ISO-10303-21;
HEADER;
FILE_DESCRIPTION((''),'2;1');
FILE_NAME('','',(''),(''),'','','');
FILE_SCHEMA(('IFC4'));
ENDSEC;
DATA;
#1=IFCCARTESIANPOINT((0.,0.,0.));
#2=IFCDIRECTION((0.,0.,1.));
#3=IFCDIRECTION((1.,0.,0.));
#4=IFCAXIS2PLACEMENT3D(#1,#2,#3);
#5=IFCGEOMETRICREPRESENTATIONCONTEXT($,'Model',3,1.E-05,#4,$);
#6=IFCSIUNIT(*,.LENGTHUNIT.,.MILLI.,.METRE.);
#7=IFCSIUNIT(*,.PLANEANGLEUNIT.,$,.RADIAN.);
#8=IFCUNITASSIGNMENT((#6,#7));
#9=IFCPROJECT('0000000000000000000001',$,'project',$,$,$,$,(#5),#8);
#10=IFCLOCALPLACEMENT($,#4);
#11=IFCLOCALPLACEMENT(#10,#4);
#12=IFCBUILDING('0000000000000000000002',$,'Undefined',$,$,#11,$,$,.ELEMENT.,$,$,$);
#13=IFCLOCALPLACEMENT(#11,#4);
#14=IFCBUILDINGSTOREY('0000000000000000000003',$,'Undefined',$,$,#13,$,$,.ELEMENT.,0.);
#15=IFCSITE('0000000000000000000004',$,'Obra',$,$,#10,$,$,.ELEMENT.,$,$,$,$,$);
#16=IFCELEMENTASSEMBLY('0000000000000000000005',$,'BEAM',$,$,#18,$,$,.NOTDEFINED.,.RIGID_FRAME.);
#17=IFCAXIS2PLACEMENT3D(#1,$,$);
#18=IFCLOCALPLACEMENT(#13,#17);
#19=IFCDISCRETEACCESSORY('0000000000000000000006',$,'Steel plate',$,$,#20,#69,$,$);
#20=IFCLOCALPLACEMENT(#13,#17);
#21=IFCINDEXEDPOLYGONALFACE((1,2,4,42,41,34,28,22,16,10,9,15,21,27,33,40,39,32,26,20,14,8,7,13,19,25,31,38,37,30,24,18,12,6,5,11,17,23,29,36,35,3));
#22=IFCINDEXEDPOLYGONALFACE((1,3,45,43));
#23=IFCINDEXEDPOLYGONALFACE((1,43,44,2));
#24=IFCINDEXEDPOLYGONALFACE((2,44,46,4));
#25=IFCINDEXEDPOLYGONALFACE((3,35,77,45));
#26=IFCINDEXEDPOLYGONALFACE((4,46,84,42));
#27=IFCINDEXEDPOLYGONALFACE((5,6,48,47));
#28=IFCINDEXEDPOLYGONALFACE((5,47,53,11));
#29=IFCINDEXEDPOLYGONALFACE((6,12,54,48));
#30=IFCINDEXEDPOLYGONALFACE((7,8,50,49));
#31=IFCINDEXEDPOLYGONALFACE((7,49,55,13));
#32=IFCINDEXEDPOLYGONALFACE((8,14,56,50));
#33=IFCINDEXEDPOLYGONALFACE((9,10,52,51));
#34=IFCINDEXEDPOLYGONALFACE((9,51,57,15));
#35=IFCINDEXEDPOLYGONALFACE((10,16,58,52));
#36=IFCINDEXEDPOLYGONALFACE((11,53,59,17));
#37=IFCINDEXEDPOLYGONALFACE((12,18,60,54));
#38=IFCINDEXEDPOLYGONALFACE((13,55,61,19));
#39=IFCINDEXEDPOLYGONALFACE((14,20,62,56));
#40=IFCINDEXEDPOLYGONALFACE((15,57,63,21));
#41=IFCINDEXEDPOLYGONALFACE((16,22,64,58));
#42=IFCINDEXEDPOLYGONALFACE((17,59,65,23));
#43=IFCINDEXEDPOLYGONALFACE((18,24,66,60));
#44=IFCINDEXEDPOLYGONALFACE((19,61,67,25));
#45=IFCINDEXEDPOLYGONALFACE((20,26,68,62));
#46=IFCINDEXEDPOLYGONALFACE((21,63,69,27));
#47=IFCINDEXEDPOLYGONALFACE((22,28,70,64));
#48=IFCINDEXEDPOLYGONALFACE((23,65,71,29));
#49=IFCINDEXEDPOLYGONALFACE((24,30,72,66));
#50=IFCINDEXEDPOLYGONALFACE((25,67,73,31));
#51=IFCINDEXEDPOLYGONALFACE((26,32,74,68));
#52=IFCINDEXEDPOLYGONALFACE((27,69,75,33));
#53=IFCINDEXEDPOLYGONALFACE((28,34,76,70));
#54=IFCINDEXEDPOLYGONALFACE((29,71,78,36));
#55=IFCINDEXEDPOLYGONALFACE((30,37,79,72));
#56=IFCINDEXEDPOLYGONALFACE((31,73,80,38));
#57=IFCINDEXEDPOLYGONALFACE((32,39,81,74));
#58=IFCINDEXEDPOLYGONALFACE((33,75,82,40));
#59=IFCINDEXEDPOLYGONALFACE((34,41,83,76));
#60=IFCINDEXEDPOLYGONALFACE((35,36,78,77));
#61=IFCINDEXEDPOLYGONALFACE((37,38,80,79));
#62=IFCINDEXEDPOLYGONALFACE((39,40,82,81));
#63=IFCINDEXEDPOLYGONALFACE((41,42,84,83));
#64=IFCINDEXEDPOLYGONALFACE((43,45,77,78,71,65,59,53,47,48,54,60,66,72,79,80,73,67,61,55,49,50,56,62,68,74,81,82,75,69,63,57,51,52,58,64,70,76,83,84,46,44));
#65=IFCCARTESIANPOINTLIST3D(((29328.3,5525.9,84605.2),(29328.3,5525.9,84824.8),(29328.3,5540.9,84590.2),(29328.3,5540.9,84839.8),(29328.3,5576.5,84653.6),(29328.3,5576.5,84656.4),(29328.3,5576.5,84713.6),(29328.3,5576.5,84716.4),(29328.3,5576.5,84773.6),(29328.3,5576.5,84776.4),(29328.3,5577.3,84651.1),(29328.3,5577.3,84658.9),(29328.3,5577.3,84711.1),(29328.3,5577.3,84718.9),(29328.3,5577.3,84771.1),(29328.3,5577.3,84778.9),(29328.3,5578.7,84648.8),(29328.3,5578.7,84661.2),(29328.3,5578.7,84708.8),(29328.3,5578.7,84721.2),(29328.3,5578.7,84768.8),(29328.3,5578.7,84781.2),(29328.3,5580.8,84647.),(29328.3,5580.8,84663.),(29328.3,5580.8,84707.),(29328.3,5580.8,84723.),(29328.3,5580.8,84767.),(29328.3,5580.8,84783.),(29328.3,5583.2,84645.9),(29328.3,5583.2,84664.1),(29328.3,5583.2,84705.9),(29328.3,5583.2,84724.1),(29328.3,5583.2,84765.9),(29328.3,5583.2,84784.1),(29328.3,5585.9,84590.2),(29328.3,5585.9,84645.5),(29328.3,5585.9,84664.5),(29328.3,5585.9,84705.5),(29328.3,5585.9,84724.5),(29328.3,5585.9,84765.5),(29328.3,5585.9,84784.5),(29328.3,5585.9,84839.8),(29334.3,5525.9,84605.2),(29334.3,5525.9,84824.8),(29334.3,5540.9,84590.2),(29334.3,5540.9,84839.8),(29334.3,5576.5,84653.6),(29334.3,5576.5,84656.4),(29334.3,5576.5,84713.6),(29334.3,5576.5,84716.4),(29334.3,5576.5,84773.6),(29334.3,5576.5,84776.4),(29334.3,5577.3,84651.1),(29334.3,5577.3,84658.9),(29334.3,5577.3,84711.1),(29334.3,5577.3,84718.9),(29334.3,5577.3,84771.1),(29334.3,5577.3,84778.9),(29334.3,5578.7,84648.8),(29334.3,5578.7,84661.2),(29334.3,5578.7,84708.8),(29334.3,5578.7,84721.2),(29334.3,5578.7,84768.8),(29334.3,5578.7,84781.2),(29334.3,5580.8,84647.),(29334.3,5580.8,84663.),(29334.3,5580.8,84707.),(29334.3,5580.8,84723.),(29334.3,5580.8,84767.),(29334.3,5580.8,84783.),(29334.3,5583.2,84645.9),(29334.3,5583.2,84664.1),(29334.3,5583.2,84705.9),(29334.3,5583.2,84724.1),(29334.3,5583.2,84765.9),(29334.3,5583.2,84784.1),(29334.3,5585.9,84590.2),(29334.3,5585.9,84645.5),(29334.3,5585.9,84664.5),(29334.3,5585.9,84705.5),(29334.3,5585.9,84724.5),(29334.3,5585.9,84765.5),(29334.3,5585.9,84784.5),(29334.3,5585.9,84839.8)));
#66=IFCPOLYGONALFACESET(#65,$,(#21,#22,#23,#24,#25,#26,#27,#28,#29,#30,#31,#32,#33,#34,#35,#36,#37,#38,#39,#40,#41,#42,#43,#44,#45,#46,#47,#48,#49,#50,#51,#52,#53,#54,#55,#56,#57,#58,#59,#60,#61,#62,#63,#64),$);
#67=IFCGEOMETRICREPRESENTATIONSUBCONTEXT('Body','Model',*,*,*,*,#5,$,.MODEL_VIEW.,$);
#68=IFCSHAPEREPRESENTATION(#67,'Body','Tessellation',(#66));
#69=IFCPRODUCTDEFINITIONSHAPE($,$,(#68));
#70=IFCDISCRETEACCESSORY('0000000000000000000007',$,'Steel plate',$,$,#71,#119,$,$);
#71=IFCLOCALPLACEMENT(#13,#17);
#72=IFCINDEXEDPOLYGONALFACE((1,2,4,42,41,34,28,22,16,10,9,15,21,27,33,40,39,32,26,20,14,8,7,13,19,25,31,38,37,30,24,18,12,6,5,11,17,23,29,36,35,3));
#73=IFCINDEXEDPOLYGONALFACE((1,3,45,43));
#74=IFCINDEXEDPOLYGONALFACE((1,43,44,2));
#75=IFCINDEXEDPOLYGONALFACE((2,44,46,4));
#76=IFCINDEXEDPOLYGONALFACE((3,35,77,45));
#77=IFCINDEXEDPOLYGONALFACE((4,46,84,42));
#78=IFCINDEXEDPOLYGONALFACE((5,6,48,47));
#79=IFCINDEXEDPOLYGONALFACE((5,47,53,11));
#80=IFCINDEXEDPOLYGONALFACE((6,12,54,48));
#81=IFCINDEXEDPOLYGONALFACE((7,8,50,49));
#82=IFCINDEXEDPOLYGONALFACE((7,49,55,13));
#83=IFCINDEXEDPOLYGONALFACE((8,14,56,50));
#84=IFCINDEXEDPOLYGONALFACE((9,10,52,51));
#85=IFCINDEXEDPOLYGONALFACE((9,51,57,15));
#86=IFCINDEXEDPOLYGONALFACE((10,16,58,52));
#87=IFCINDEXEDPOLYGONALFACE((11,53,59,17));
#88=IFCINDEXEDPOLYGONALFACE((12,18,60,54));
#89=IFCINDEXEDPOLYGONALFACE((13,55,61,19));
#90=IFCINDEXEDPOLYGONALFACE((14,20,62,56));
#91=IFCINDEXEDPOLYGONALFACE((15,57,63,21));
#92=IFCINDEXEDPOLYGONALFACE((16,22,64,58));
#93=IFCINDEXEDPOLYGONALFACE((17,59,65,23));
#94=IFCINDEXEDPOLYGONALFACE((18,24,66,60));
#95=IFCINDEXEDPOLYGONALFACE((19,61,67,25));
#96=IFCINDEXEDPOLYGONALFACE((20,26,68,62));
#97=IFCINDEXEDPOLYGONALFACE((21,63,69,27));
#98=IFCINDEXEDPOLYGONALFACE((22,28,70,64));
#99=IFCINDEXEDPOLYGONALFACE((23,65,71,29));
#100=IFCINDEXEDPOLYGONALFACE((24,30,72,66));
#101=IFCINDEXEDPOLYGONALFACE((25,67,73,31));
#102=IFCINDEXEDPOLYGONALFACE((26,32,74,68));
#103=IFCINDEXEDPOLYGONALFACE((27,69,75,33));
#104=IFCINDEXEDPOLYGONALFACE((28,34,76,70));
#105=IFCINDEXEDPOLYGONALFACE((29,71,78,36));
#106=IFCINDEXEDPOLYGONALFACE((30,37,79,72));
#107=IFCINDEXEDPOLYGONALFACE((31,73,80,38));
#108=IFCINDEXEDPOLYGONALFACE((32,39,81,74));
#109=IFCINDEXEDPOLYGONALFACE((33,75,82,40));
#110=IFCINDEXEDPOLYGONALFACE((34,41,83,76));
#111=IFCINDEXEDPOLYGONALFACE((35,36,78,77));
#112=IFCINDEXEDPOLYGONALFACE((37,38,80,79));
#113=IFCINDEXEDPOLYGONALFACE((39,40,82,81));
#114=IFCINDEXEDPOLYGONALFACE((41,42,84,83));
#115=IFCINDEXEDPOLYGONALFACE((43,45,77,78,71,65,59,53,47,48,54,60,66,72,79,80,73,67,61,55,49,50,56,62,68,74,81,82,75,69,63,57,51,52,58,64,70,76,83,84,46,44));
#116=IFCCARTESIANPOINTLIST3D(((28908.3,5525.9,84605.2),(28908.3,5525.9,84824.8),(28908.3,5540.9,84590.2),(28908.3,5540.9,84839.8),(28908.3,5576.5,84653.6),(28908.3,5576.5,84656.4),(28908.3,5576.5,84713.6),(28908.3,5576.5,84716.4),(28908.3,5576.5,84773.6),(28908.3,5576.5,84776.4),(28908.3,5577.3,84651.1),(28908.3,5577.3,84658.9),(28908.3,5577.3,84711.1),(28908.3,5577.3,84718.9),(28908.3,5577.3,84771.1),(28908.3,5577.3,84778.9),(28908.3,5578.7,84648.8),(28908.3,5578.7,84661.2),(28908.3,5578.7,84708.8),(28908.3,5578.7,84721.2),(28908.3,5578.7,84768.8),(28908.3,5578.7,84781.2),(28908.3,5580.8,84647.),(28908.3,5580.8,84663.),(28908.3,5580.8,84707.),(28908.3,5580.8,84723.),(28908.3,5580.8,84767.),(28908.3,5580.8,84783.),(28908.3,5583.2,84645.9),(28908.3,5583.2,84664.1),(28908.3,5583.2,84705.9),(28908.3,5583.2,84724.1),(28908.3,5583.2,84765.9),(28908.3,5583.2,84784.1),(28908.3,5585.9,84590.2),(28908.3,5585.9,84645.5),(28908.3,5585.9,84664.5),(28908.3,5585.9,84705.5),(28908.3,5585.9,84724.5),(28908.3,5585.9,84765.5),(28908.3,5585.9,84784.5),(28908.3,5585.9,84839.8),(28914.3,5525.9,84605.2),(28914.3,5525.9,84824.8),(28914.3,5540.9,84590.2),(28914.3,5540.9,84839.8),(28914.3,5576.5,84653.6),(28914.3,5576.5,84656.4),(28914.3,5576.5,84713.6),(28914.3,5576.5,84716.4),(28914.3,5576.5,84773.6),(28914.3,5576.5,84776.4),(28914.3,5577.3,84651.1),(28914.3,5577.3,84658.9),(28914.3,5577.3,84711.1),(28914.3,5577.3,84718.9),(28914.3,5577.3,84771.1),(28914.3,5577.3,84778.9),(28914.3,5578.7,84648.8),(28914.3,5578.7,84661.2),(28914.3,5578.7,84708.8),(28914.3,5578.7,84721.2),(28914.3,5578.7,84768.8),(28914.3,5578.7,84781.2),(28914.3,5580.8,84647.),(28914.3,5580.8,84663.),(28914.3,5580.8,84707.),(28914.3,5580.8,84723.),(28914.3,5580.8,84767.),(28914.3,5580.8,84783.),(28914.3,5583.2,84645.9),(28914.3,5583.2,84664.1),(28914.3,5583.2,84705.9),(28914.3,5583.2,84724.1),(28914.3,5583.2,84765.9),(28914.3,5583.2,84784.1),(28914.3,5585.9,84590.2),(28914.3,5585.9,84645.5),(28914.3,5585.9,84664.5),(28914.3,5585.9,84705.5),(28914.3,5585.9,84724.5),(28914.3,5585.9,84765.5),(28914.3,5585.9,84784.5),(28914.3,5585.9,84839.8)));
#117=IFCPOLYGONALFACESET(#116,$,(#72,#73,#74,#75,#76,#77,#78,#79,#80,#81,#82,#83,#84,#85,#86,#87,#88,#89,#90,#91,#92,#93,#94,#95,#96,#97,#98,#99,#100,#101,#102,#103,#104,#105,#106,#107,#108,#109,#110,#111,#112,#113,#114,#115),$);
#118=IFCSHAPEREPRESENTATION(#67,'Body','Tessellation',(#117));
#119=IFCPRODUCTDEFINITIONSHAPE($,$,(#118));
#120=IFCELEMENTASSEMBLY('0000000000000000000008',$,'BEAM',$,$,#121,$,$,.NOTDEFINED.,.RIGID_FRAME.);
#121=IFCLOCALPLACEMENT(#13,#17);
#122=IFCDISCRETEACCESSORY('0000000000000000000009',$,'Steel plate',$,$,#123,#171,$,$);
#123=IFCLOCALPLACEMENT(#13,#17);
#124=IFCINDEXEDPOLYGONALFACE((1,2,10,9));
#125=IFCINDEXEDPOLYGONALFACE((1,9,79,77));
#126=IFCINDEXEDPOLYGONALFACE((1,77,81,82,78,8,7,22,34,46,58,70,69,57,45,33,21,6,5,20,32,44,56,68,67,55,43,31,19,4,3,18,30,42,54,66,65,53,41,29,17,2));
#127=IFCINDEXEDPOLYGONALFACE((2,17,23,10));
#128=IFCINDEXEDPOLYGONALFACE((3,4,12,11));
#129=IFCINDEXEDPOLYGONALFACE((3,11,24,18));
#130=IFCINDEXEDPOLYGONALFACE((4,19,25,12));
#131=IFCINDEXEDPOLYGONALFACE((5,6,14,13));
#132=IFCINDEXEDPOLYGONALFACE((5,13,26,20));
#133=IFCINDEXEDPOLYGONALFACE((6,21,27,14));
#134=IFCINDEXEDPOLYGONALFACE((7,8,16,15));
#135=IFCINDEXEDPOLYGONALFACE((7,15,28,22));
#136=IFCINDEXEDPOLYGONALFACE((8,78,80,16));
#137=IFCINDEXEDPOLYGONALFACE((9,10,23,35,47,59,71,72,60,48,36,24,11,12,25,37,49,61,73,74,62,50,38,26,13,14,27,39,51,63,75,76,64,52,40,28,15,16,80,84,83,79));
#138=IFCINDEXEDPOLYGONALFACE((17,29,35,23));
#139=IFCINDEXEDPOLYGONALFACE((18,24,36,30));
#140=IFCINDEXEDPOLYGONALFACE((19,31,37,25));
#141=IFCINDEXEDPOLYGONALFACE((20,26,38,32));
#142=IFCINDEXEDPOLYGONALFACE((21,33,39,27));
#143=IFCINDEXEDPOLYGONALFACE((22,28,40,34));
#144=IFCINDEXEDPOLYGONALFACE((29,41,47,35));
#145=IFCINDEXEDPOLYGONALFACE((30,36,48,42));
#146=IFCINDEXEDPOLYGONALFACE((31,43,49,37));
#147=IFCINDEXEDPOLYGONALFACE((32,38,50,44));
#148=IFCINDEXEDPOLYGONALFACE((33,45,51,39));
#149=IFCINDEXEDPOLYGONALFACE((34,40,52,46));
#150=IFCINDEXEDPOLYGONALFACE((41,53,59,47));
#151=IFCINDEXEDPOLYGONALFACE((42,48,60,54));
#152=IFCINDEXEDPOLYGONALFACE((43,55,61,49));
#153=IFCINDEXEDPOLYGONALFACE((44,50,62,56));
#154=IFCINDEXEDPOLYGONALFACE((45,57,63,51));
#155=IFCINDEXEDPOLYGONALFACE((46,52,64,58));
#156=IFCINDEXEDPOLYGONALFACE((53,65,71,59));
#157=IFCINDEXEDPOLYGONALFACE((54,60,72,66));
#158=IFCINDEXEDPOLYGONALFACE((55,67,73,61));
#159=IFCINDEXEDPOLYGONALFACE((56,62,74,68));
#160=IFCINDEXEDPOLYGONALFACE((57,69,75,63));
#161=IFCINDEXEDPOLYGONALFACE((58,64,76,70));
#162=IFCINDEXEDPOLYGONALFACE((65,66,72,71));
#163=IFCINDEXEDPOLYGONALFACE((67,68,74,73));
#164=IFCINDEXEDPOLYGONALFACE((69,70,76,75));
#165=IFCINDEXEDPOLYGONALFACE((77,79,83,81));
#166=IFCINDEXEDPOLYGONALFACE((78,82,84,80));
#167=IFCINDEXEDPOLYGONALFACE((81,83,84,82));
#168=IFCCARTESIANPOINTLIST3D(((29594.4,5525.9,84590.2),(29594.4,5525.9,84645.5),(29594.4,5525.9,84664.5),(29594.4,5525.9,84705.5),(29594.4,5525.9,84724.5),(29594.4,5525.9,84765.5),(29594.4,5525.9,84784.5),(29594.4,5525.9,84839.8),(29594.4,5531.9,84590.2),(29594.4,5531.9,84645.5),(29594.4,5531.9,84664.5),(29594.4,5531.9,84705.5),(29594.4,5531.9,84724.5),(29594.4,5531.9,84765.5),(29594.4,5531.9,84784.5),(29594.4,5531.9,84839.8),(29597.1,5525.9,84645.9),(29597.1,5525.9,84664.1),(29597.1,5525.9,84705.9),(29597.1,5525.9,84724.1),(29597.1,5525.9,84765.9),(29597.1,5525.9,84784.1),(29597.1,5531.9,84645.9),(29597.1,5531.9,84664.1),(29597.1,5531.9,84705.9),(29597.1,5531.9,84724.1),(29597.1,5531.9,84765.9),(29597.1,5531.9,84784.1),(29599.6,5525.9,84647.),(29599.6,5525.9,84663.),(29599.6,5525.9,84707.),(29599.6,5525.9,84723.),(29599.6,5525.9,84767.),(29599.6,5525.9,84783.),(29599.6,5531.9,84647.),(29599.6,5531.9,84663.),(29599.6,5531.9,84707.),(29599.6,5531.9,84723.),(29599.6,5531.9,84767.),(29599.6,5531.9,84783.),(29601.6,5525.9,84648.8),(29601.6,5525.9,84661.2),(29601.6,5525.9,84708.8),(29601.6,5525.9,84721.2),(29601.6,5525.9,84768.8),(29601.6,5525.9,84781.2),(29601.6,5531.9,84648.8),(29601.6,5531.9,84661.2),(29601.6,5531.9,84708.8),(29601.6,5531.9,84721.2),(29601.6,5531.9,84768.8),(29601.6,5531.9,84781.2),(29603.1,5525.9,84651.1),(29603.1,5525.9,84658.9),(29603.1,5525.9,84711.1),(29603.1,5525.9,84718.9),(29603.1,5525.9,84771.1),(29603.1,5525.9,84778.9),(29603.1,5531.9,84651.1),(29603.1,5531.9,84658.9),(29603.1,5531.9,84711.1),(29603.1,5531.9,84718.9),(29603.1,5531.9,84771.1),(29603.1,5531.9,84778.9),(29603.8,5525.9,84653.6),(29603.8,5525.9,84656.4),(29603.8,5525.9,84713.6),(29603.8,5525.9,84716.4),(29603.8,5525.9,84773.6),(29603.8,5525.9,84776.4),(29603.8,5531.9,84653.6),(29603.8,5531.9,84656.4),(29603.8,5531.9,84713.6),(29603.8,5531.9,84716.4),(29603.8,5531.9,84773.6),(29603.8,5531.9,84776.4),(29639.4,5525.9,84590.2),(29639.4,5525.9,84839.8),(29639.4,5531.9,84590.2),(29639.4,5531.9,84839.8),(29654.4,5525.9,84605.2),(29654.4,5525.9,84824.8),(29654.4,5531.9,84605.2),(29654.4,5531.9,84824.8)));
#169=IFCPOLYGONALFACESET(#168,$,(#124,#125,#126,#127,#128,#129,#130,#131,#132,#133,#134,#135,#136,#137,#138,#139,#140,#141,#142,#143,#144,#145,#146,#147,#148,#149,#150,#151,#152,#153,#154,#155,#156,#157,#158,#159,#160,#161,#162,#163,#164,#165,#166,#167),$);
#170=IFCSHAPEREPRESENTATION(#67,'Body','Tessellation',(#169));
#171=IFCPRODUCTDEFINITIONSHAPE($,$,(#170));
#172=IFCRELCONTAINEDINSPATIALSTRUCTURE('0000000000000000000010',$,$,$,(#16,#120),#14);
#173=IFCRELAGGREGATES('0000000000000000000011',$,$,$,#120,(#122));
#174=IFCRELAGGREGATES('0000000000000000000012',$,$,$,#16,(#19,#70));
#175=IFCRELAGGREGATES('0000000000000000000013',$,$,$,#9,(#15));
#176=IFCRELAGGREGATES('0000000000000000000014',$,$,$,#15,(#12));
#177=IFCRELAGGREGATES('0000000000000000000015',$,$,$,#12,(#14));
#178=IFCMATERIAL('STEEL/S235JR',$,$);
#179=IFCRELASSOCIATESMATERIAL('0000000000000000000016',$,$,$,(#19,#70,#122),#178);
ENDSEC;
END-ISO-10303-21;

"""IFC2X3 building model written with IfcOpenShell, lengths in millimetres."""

from ifc_helpers import new_model, si_unit, frame, origin_with_axes, origin_2d_with_axis, place, context, subcontext, project, spatial, polyline, circle, outline, extrude, source, transform, mapped, material, element, aggregate, save


model = new_model("IFC2X3")

# Units and contexts
model_context = context("Model", 3, precision=1e-05, world=origin_with_axes())
body_context = subcontext(model_context, "Body", "Model", "MODEL_VIEW")
ifc_project = project(units=[si_unit("LENGTHUNIT", "METRE", prefix="MILLI"), si_unit("PLANEANGLEUNIT", "RADIAN")], contexts=[model_context])

# Site, building, storey
site_placement = place(None, origin_with_axes())
site = spatial("IfcSite", under=ifc_project, at=site_placement, Name="Obra", CompositionType="ELEMENT")
building_placement = place(site_placement, origin_with_axes())
building = spatial("IfcBuilding", under=site, at=building_placement, Name="Undefined", CompositionType="ELEMENT")
storey_placement = place(building_placement, origin_with_axes())
storey = spatial("IfcBuildingStorey", under=building, at=storey_placement, Name="Undefined", CompositionType="ELEMENT", Elevation=0.0)

# Shared definitions
ifc_material_1 = material(Name="STEEL/S235JR")

# Element assembly, discrete accessories, openings
assembly_1_placement = place(storey_placement, origin_with_axes())
assembly_1 = element("IfcElementAssembly", 1, at=assembly_1_placement, inside=storey, Name="BEAM", AssemblyPlace="NOTDEFINED", PredefinedType="RIGID_FRAME")
discrete_accessory_1_placement = place(assembly_1_placement, frame((29331.3, 5585.9, 84590.2), z_axis=(-1.0, -0.000002, 0.0), x_axis=(0.000002, -1.0, 0.0)))
discrete_accessory_1 = element("IfcDiscreteAccessory", 2, at=discrete_accessory_1_placement, material=ifc_material_1, Name="Steel plate", context=body_context, shape_type="SweptSolid", body=[
    extrude(outline(polyline([(0.0, 0.0), (45.0, 0.0), (60.0, 15.0), (60.0, 234.6), (45.0, 249.6), (0.0, 249.6), (0.0, 0.0)])), frame((0.0, 0.0, -3.0), z_axis=(0.0, 0.0, 1.0), x_axis=(1.0, 0.0, 0.0)), (0.0, 0.0, 1.0), 6.0),
])
shared_shape_1 = source(origin_with_axes(), body_context, "Body", "SweptSolid", [
    extrude(circle(Radius=9.5, at=origin_2d_with_axis()), frame((0.0, -9.4, 0.0), z_axis=(0.0, 1.0, 0.0), x_axis=(1.0, 0.0, 0.0)), (0.0, 0.0, 1.0), 6.2),
])
opening_1_placement = place(assembly_1_placement, frame((29325.0, 5535.9, 84850.0), z_axis=(-0.000002, 1.0, 0.0), x_axis=(0.0, 0.0, -1.0)))
element("IfcOpeningElement", 3, at=opening_1_placement, cuts=discrete_accessory_1, ObjectType="Opening", context=body_context, shape_type="MappedRepresentation", body=[
    mapped(shared_shape_1, transform((75.0, 0.0, 50.0))),
    mapped(shared_shape_1, transform((135.0, 0.0, 50.0))),
    mapped(shared_shape_1, transform((195.0, 0.0, 50.0))),
])
discrete_accessory_2_placement = place(assembly_1_placement, frame((28911.3, 5585.9, 84590.2), z_axis=(-1.0, -0.000002, 0.0), x_axis=(0.000002, -1.0, 0.0)))
discrete_accessory_2 = element("IfcDiscreteAccessory", 4, at=discrete_accessory_2_placement, material=ifc_material_1, Name="Steel plate", context=body_context, shape_type="SweptSolid", body=[
    extrude(outline(polyline([(0.0, 0.0), (45.0, 0.0), (60.0, 15.0), (60.0, 234.6), (45.0, 249.6), (0.0, 249.6), (0.0, 0.0)])), frame((0.0, 0.0, -3.0), z_axis=(0.0, 0.0, 1.0), x_axis=(1.0, 0.0, 0.0)), (0.0, 0.0, 1.0), 6.0),
])
opening_2_placement = place(assembly_1_placement, frame((28905.0, 5535.9, 84850.0), z_axis=(-0.000002, 1.0, 0.0), x_axis=(0.0, 0.0, -1.0)))
element("IfcOpeningElement", 5, at=opening_2_placement, cuts=discrete_accessory_2, ObjectType="Opening", context=body_context, shape_type="MappedRepresentation", body=[
    mapped(shared_shape_1, transform((75.0, 0.0, 50.0))),
    mapped(shared_shape_1, transform((135.0, 0.0, 50.0))),
    mapped(shared_shape_1, transform((195.0, 0.0, 50.0))),
])

# Element assembly, discrete accessory, opening
assembly_2_placement = place(storey_placement, origin_with_axes())
assembly_2 = element("IfcElementAssembly", 6, at=assembly_2_placement, inside=storey, Name="BEAM", AssemblyPlace="NOTDEFINED", PredefinedType="RIGID_FRAME")
discrete_accessory_3_placement = place(assembly_2_placement, frame((29594.4, 5528.9, 84590.2), z_axis=(0.0, -1.0, 0.0), x_axis=(1.0, 0.0, 0.0)))
discrete_accessory_3 = element("IfcDiscreteAccessory", 7, at=discrete_accessory_3_placement, material=ifc_material_1, Name="Steel plate", context=body_context, shape_type="SweptSolid", body=[
    extrude(outline(polyline([(0.0, 0.0), (45.0, 0.0), (60.0, 15.0), (60.0, 234.6), (45.0, 249.6), (0.0, 249.6), (0.0, 0.0)])), frame((0.0, 0.0, -3.0), z_axis=(0.0, 0.0, 1.0), x_axis=(1.0, 0.0, 0.0)), (0.0, 0.0, 1.0), 6.0),
])
opening_3_placement = place(assembly_2_placement, frame((29644.4, 5522.6, 84850.0), z_axis=(-1.0, 0.0, 0.0), x_axis=(0.0, 0.0, -1.0)))
element("IfcOpeningElement", 8, at=opening_3_placement, cuts=discrete_accessory_3, ObjectType="Opening", context=body_context, shape_type="MappedRepresentation", body=[
    mapped(shared_shape_1, transform((75.0, 0.0, 50.0))),
    mapped(shared_shape_1, transform((135.0, 0.0, 50.0))),
    mapped(shared_shape_1, transform((195.0, 0.0, 50.0))),
])
aggregate(assembly_2, [discrete_accessory_3])

aggregate(assembly_1, [discrete_accessory_1, discrete_accessory_2])

save(model, "model.ifc")
